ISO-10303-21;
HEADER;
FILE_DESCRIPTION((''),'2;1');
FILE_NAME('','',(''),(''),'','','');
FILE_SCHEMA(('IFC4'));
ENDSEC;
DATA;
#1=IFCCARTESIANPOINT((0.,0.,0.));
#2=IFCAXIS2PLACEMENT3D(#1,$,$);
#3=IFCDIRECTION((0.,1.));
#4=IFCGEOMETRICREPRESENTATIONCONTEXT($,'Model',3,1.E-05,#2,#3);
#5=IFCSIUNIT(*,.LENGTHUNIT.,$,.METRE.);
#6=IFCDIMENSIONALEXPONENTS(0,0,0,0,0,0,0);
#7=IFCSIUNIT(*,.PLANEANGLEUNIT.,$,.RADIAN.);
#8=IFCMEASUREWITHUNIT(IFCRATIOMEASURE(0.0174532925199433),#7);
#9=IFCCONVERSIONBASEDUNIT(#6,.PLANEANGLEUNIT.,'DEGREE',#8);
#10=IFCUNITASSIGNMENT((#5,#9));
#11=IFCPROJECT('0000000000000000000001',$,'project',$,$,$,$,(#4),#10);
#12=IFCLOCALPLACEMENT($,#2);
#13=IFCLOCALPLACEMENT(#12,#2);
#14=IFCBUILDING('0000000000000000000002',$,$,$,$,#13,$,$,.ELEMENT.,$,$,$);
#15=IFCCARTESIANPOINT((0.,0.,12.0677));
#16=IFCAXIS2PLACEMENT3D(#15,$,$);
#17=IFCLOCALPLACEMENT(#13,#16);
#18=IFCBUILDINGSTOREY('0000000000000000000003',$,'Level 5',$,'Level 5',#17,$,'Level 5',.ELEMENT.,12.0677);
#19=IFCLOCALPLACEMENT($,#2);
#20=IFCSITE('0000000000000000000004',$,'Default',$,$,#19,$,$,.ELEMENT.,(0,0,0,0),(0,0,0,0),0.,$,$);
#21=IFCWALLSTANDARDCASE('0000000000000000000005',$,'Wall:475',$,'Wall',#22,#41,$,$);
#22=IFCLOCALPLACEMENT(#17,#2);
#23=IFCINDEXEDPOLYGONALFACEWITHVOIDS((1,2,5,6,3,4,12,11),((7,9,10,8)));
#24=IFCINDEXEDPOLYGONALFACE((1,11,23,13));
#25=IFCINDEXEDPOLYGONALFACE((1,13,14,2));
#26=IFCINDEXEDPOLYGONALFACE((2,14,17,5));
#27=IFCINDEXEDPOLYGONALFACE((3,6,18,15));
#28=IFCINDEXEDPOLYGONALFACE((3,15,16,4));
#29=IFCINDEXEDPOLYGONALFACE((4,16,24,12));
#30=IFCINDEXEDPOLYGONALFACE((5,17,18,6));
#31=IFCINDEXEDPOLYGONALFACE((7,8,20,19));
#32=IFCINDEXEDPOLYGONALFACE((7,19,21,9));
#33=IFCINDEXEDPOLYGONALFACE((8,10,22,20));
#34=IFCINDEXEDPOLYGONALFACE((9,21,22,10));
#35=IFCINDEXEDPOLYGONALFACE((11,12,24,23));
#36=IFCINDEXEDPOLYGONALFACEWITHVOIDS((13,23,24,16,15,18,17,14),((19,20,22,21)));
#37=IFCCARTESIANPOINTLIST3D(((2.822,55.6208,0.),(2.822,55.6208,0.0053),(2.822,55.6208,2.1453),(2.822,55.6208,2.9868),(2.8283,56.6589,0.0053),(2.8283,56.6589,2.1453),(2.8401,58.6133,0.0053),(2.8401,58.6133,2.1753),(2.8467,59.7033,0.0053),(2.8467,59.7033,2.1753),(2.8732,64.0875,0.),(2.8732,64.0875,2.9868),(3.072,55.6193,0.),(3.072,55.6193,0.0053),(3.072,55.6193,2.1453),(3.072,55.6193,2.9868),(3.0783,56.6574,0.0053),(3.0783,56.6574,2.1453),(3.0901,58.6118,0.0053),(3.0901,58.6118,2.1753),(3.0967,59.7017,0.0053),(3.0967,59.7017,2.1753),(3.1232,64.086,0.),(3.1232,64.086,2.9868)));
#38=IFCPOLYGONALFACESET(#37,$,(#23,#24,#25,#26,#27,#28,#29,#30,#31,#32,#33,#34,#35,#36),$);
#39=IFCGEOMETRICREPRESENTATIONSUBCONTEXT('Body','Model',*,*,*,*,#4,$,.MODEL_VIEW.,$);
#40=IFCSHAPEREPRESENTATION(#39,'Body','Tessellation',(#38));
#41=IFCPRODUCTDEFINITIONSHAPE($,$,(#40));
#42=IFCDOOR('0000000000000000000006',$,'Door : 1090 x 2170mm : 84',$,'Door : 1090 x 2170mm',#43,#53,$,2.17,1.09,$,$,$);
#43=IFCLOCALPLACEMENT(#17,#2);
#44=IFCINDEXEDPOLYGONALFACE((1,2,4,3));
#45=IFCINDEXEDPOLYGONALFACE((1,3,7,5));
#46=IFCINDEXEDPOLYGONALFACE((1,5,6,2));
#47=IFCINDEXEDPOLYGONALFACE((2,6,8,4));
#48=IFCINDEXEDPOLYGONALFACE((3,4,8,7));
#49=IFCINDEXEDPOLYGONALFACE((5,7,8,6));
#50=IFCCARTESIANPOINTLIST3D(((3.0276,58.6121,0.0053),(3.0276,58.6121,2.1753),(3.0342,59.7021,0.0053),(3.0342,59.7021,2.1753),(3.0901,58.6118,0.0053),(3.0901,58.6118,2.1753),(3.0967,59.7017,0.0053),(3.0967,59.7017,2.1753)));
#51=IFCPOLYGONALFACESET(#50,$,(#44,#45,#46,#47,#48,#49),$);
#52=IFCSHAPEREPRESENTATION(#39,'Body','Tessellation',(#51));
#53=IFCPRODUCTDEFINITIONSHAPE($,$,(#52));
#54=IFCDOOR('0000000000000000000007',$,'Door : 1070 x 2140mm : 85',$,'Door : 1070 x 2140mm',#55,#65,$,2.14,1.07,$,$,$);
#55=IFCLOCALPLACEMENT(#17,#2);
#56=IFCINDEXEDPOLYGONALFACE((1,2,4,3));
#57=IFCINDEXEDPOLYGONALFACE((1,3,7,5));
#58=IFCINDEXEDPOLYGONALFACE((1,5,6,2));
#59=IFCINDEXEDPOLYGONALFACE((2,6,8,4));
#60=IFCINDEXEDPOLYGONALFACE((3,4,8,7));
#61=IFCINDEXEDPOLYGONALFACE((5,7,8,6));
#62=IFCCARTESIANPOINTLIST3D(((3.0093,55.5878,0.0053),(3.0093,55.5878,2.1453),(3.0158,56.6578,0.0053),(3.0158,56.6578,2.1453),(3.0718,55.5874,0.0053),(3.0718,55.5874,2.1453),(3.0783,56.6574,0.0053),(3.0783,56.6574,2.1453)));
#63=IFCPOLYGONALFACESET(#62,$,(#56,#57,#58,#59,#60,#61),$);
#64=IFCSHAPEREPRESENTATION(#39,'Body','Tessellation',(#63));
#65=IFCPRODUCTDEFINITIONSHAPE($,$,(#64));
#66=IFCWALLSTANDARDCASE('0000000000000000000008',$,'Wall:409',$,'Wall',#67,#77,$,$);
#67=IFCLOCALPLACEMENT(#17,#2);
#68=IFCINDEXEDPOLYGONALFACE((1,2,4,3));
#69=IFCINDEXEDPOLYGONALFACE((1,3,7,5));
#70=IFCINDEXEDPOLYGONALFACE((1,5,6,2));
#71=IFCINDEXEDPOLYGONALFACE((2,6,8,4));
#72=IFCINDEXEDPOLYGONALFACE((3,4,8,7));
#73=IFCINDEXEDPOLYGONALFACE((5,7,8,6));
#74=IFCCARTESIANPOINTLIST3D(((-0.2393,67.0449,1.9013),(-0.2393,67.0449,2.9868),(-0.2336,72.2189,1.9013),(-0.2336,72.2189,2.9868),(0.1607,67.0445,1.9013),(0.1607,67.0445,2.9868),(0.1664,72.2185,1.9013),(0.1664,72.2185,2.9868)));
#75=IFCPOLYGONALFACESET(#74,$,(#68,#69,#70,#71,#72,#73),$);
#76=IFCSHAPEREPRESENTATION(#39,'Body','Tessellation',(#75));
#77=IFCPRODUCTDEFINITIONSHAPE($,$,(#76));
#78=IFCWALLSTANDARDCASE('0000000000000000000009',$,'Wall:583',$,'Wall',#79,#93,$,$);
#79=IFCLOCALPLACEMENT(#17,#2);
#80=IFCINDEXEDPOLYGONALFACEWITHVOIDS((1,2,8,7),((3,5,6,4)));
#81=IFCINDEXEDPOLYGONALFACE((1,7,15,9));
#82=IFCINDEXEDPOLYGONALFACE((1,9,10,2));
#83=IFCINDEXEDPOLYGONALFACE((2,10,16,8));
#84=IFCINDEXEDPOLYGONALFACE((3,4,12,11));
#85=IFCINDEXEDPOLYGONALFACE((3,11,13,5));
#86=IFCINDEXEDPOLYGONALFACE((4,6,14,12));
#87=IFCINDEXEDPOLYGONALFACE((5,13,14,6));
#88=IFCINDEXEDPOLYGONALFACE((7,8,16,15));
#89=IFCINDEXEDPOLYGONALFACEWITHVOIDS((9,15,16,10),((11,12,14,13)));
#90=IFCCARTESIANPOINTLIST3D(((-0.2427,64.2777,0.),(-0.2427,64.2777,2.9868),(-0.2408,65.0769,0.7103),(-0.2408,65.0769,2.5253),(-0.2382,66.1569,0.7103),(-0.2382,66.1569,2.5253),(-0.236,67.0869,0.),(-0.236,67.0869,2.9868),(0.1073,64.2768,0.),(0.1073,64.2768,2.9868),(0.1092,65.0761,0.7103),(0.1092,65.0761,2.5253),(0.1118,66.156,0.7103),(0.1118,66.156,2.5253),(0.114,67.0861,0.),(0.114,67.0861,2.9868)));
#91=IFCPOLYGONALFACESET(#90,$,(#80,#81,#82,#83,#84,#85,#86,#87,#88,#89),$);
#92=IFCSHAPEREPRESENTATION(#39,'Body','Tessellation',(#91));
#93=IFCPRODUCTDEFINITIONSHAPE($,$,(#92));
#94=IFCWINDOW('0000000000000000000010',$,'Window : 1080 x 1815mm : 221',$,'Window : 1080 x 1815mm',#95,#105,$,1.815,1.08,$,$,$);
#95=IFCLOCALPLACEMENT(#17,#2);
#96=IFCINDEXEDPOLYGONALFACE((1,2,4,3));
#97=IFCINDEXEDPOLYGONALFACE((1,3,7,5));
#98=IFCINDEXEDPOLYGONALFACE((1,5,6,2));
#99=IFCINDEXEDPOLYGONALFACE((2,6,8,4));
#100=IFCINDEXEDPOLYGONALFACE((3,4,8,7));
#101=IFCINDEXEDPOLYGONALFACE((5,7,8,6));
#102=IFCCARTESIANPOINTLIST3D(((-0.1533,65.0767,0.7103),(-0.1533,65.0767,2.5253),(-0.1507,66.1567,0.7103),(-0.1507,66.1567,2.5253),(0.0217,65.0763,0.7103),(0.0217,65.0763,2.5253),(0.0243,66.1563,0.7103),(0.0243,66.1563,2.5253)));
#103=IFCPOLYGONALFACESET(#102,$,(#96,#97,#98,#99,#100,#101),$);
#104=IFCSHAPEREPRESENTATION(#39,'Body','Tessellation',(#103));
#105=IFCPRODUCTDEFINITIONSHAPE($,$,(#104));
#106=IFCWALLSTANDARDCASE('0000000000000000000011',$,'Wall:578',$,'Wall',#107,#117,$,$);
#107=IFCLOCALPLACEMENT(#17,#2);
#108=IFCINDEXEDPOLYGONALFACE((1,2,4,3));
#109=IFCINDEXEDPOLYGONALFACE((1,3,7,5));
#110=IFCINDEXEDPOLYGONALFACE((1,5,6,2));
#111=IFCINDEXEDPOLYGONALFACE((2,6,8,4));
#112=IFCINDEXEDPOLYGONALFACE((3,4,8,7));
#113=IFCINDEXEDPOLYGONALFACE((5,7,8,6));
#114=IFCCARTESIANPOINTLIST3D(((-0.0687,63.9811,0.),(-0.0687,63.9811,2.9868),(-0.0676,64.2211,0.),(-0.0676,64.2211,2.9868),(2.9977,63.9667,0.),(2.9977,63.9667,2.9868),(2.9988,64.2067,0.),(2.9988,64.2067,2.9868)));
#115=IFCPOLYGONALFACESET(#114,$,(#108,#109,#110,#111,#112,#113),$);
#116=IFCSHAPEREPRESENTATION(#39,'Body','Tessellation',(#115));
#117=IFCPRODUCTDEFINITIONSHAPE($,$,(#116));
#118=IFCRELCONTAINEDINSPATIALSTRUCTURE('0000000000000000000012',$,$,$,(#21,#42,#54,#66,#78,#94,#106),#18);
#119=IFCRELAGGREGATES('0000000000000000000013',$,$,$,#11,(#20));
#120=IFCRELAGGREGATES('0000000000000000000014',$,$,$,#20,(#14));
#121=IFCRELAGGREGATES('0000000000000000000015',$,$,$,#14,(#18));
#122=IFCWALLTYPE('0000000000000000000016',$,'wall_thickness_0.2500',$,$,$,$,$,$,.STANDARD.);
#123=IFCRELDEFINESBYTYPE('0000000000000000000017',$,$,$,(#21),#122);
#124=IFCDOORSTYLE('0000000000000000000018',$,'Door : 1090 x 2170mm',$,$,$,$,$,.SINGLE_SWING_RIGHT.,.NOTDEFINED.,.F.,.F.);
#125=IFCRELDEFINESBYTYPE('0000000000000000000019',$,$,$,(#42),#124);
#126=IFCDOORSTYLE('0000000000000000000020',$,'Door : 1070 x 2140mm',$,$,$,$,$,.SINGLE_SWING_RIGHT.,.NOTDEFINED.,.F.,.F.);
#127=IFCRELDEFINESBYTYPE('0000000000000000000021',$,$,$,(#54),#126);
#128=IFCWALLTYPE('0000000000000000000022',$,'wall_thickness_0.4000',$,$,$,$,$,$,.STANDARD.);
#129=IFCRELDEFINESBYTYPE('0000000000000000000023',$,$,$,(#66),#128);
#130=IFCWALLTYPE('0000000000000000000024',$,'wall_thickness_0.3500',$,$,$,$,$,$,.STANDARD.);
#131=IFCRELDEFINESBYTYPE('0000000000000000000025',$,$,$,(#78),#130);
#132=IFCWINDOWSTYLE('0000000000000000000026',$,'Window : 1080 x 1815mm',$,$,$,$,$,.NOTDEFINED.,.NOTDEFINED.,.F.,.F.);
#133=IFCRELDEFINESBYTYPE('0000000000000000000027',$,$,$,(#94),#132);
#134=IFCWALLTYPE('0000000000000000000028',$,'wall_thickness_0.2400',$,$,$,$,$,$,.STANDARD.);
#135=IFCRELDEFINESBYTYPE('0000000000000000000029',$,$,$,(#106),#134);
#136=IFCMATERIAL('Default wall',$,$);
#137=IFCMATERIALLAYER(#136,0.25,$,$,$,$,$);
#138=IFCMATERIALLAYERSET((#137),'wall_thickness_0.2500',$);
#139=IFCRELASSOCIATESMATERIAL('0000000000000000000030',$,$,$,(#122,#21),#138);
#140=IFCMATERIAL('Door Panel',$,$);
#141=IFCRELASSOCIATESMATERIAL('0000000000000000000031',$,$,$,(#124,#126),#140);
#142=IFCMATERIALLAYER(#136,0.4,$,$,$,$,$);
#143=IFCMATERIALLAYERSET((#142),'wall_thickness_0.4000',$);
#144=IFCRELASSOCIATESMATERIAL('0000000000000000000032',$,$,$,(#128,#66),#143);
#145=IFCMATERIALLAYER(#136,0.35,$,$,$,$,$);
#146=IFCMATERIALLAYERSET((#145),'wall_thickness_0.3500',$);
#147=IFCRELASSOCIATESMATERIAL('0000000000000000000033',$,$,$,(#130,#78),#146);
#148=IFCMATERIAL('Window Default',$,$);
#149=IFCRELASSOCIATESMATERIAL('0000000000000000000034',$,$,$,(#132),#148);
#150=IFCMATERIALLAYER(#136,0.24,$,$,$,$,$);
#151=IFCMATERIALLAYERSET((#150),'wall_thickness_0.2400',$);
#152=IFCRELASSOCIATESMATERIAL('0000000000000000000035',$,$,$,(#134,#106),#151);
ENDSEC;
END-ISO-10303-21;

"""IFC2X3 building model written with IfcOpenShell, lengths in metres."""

from ifc_helpers import new_model, entity, si_unit, converted_unit, direction, frame, frame_2d, origin, origin_2d_with_axis, place, context, subcontext, project, spatial, polyline, rectangle, outline, extrude, source, transform, mapped, material, layer, layer_set, layer_usage, type_object, type_shapes, element, fill, save


model = new_model("IFC2X3")

# Units and contexts
model_context = context("Model", 3, precision=1e-05, world=origin(), true_north=direction((0.0, 1.0)))
body_context = subcontext(model_context, "Body", "Model", "MODEL_VIEW")
ifc_project = project(units=[si_unit("LENGTHUNIT", "METRE"), converted_unit("PLANEANGLEUNIT", "DEGREE", entity("IfcRatioMeasure", 0.0174532925199433), si_unit("PLANEANGLEUNIT", "RADIAN"), dimensions=[0, 0, 0, 0, 0, 0, 0])], contexts=[model_context])

# Site, building, storey
site_placement = place(None, origin())
site = spatial("IfcSite", under=ifc_project, at=site_placement, Name="Default", CompositionType="ELEMENT", RefLatitude=(0, 0, 0, 0), RefLongitude=(0, 0, 0, 0), RefElevation=0.0)
placement_1 = place(None, origin())
building_placement = place(placement_1, origin())
building = spatial("IfcBuilding", under=site, at=building_placement, CompositionType="ELEMENT")
storey_placement = place(building_placement, frame((0.0, 0.0, 12.0677)))
storey = spatial("IfcBuildingStorey", under=building, at=storey_placement, Name="Level 5", ObjectType="Level 5", LongName="Level 5", CompositionType="ELEMENT", Elevation=12.0677)

# Shared definitions
ifc_material_1 = material(Name="Default wall")

# Shared definitions
ifc_material_2 = material(Name="Window Default")

# Wall, openings, doors
ifc_layer_1 = layer(ifc_material_1, 0.25)
ifc_layer_set_1 = layer_set([ifc_layer_1], Name="wall_thickness_0.2500")
ifc_layer_usage_1 = layer_usage(ifc_layer_set_1, "AXIS2", "POSITIVE", -0.125)
wall_type_1 = type_object("IfcWallType", Name="wall_thickness_0.2500", PredefinedType="STANDARD", material=ifc_layer_set_1)
ifc_material_3 = material(Name="Door Panel")
wall_1_placement = place(storey_placement, frame((2.9982, 64.0867, 0.0), z_axis=(0.0, 0.0, 1.0), x_axis=(-0.006046, -0.999982, 0.0)))
wall_1 = element("IfcWallStandardCase", 1, at=wall_1_placement, inside=storey, type_object=wall_type_1, material=ifc_layer_usage_1, Name="Wall:475", ObjectType="Wall", context=body_context, shape_type="SweptSolid", body=[
    extrude(outline(polyline([(8.4668, -0.125), (8.4668, 0.125), (0.0, 0.125), (0.0, -0.125), (8.4668, -0.125)])), origin(), (0.0, 0.0, 1.0), 2.9868),
])
opening_1_placement = place(wall_1_placement, frame((4.3843, -0.125, 0.0053)))
opening_1 = element("IfcOpeningElement", 2, at=opening_1_placement, cuts=wall_1, ObjectType="Opening", context=body_context, shape_type="SweptSolid", body=[
    extrude(rectangle(XDim=1.09, YDim=2.17, at=frame_2d((1.085, 0.545), x_axis=(0.0, 1.0))), frame((0.0, 0.0, 0.0), z_axis=(0.0, 1.0, 0.0), x_axis=(0.0, 0.0, 1.0)), (0.0, 0.0, 1.0), 0.25),
])
opening_2_placement = place(wall_1_placement, frame((7.4287, -0.125, 0.0053)))
opening_2 = element("IfcOpeningElement", 3, at=opening_2_placement, cuts=wall_1, ObjectType="Opening", context=body_context, shape_type="SweptSolid", body=[
    extrude(rectangle(XDim=1.07, YDim=2.14, at=frame_2d((1.07, 0.535), x_axis=(0.0, 1.0))), frame((0.0, 0.0, 0.0), z_axis=(0.0, 1.0, 0.0), x_axis=(0.0, 0.0, 1.0)), (0.0, 0.0, 1.0), 0.25),
])
door_style_1 = type_object("IfcDoorStyle", Name="Door : 1090 x 2170mm", ConstructionType="NOTDEFINED", OperationType="SINGLE_SWING_RIGHT", ParameterTakesPrecedence=False, Sizeable=False, material=ifc_material_3)
shared_shape_1 = source(origin(), body_context, "Body", "SweptSolid", [
    extrude(rectangle(XDim=0.0625, YDim=1.09, at=origin_2d_with_axis()), frame((0.545, 0.2188, 0.0), z_axis=(0.0, 0.0, 1.0), x_axis=(0.0, 1.0, 0.0)), (0.0, 0.0, 1.0), 2.17),
])
type_shapes(door_style_1, [shared_shape_1])
door_1_placement = place(opening_1_placement, origin())
door_1 = element("IfcDoor", 4, at=door_1_placement, inside=storey, type_object=door_style_1, Name="Door : 1090 x 2170mm : 84", ObjectType="Door : 1090 x 2170mm", OverallHeight=2.17, OverallWidth=1.09, context=body_context, shape_type="MappedRepresentation", body=[
    mapped(shared_shape_1, transform((0.0, 0.0, 0.0), scale=1.0)),
])
fill(opening_1, door_1)
door_style_2 = type_object("IfcDoorStyle", Name="Door : 1070 x 2140mm", ConstructionType="NOTDEFINED", OperationType="SINGLE_SWING_RIGHT", ParameterTakesPrecedence=False, Sizeable=False, material=ifc_material_3)
shared_shape_2 = source(origin(), body_context, "Body", "SweptSolid", [
    extrude(rectangle(XDim=0.0625, YDim=1.07, at=origin_2d_with_axis()), frame((0.535, 0.2188, 0.0), z_axis=(0.0, 0.0, 1.0), x_axis=(0.0, 1.0, 0.0)), (0.0, 0.0, 1.0), 2.14),
])
type_shapes(door_style_2, [shared_shape_2])
door_2_placement = place(opening_2_placement, origin())
door_2 = element("IfcDoor", 5, at=door_2_placement, inside=storey, type_object=door_style_2, Name="Door : 1070 x 2140mm : 85", ObjectType="Door : 1070 x 2140mm", OverallHeight=2.14, OverallWidth=1.07, context=body_context, shape_type="MappedRepresentation", body=[
    mapped(shared_shape_2, transform((0.0, 0.0, 0.0), scale=1.0)),
])
fill(opening_2, door_2)

# Wall
ifc_layer_2 = layer(ifc_material_1, 0.4)
ifc_layer_set_2 = layer_set([ifc_layer_2], Name="wall_thickness_0.4000")
ifc_layer_usage_2 = layer_usage(ifc_layer_set_2, "AXIS2", "POSITIVE", -0.2)
wall_type_2 = type_object("IfcWallType", Name="wall_thickness_0.4000", PredefinedType="STANDARD", material=ifc_layer_set_2)
placement_2 = place(building_placement, frame((0.0, 0.0, 13.969)))
wall_2_placement = place(placement_2, frame((-0.0336, 72.2187, 0.0), z_axis=(0.0, 0.0, 1.0), x_axis=(-0.001112, -0.999999, 0.0)))
element("IfcWallStandardCase", 6, at=wall_2_placement, inside=storey, type_object=wall_type_2, material=ifc_layer_usage_2, Name="Wall:409", ObjectType="Wall", context=body_context, shape_type="SweptSolid", body=[
    extrude(outline(polyline([(5.174, -0.2), (5.174, 0.2), (0.0, 0.2), (0.0, -0.2), (5.174, -0.2)])), origin(), (0.0, 0.0, 1.0), 1.0855),
])

# Wall, opening, window
ifc_layer_3 = layer(ifc_material_1, 0.35)
ifc_layer_set_3 = layer_set([ifc_layer_3], Name="wall_thickness_0.3500")
ifc_layer_usage_3 = layer_usage(ifc_layer_set_3, "AXIS2", "POSITIVE", -0.175)
wall_type_3 = type_object("IfcWallType", Name="wall_thickness_0.3500", PredefinedType="STANDARD", material=ifc_layer_set_3)
wall_3_placement = place(storey_placement, frame((-0.061, 67.0865, 0.0), z_axis=(0.0, 0.0, 1.0), x_axis=(-0.002393, -0.999997, 0.0)))
wall_3 = element("IfcWallStandardCase", 7, at=wall_3_placement, inside=storey, type_object=wall_type_3, material=ifc_layer_usage_3, Name="Wall:583", ObjectType="Wall", context=body_context, shape_type="SweptSolid", body=[
    extrude(outline(polyline([(2.8092, -0.175), (2.8092, 0.175), (0.0, 0.175), (0.0, -0.175), (2.8092, -0.175)])), origin(), (0.0, 0.0, 1.0), 2.9868),
])
opening_3_placement = place(wall_3_placement, frame((0.93, -0.175, 0.7103)))
opening_3 = element("IfcOpeningElement", 8, at=opening_3_placement, cuts=wall_3, ObjectType="Opening", context=body_context, shape_type="SweptSolid", body=[
    extrude(rectangle(XDim=1.08, YDim=1.815, at=frame_2d((0.9075, 0.54), x_axis=(0.0, 1.0))), frame((0.0, 0.0, 0.0), z_axis=(0.0, 1.0, 0.0), x_axis=(0.0, 0.0, 1.0)), (0.0, 0.0, 1.0), 0.35),
])
window_style_1 = type_object("IfcWindowStyle", Name="Window : 1080 x 1815mm", ConstructionType="NOTDEFINED", OperationType="NOTDEFINED", ParameterTakesPrecedence=False, Sizeable=False, material=ifc_material_2)
shared_shape_3 = source(origin(), body_context, "Body", "SweptSolid", [
    extrude(rectangle(XDim=0.175, YDim=1.08, at=origin_2d_with_axis()), frame((0.54, 0.175, 0.0), z_axis=(0.0, 0.0, 1.0), x_axis=(0.0, 1.0, 0.0)), (0.0, 0.0, 1.0), 1.815),
])
type_shapes(window_style_1, [shared_shape_3])
window_1_placement = place(opening_3_placement, origin())
window_1 = element("IfcWindow", 9, at=window_1_placement, inside=storey, type_object=window_style_1, Name="Window : 1080 x 1815mm : 221", ObjectType="Window : 1080 x 1815mm", OverallHeight=1.815, OverallWidth=1.08, context=body_context, shape_type="MappedRepresentation", body=[
    mapped(shared_shape_3, transform((0.0, 0.0, 0.0), scale=1.0)),
])
fill(opening_3, window_1)

# Wall
ifc_layer_4 = layer(ifc_material_1, 0.24)
ifc_layer_set_4 = layer_set([ifc_layer_4], Name="wall_thickness_0.2400")
ifc_layer_usage_4 = layer_usage(ifc_layer_set_4, "AXIS2", "POSITIVE", -0.12)
wall_type_4 = type_object("IfcWallType", Name="wall_thickness_0.2400", PredefinedType="STANDARD", material=ifc_layer_set_4)
wall_4_placement = place(storey_placement, frame((-0.0681, 64.1011, 0.0), z_axis=(0.0, 0.0, 1.0), x_axis=(0.999989, -0.004668, 0.0)))
element("IfcWallStandardCase", 10, at=wall_4_placement, inside=storey, type_object=wall_type_4, material=ifc_layer_usage_4, Name="Wall:578", ObjectType="Wall", context=body_context, shape_type="SweptSolid", body=[
    extrude(outline(polyline([(3.0664, -0.12), (3.0664, 0.12), (0.0, 0.12), (0.0, -0.12), (3.0664, -0.12)])), origin(), (0.0, 0.0, 1.0), 2.9868),
])

save(model, "model.ifc")
